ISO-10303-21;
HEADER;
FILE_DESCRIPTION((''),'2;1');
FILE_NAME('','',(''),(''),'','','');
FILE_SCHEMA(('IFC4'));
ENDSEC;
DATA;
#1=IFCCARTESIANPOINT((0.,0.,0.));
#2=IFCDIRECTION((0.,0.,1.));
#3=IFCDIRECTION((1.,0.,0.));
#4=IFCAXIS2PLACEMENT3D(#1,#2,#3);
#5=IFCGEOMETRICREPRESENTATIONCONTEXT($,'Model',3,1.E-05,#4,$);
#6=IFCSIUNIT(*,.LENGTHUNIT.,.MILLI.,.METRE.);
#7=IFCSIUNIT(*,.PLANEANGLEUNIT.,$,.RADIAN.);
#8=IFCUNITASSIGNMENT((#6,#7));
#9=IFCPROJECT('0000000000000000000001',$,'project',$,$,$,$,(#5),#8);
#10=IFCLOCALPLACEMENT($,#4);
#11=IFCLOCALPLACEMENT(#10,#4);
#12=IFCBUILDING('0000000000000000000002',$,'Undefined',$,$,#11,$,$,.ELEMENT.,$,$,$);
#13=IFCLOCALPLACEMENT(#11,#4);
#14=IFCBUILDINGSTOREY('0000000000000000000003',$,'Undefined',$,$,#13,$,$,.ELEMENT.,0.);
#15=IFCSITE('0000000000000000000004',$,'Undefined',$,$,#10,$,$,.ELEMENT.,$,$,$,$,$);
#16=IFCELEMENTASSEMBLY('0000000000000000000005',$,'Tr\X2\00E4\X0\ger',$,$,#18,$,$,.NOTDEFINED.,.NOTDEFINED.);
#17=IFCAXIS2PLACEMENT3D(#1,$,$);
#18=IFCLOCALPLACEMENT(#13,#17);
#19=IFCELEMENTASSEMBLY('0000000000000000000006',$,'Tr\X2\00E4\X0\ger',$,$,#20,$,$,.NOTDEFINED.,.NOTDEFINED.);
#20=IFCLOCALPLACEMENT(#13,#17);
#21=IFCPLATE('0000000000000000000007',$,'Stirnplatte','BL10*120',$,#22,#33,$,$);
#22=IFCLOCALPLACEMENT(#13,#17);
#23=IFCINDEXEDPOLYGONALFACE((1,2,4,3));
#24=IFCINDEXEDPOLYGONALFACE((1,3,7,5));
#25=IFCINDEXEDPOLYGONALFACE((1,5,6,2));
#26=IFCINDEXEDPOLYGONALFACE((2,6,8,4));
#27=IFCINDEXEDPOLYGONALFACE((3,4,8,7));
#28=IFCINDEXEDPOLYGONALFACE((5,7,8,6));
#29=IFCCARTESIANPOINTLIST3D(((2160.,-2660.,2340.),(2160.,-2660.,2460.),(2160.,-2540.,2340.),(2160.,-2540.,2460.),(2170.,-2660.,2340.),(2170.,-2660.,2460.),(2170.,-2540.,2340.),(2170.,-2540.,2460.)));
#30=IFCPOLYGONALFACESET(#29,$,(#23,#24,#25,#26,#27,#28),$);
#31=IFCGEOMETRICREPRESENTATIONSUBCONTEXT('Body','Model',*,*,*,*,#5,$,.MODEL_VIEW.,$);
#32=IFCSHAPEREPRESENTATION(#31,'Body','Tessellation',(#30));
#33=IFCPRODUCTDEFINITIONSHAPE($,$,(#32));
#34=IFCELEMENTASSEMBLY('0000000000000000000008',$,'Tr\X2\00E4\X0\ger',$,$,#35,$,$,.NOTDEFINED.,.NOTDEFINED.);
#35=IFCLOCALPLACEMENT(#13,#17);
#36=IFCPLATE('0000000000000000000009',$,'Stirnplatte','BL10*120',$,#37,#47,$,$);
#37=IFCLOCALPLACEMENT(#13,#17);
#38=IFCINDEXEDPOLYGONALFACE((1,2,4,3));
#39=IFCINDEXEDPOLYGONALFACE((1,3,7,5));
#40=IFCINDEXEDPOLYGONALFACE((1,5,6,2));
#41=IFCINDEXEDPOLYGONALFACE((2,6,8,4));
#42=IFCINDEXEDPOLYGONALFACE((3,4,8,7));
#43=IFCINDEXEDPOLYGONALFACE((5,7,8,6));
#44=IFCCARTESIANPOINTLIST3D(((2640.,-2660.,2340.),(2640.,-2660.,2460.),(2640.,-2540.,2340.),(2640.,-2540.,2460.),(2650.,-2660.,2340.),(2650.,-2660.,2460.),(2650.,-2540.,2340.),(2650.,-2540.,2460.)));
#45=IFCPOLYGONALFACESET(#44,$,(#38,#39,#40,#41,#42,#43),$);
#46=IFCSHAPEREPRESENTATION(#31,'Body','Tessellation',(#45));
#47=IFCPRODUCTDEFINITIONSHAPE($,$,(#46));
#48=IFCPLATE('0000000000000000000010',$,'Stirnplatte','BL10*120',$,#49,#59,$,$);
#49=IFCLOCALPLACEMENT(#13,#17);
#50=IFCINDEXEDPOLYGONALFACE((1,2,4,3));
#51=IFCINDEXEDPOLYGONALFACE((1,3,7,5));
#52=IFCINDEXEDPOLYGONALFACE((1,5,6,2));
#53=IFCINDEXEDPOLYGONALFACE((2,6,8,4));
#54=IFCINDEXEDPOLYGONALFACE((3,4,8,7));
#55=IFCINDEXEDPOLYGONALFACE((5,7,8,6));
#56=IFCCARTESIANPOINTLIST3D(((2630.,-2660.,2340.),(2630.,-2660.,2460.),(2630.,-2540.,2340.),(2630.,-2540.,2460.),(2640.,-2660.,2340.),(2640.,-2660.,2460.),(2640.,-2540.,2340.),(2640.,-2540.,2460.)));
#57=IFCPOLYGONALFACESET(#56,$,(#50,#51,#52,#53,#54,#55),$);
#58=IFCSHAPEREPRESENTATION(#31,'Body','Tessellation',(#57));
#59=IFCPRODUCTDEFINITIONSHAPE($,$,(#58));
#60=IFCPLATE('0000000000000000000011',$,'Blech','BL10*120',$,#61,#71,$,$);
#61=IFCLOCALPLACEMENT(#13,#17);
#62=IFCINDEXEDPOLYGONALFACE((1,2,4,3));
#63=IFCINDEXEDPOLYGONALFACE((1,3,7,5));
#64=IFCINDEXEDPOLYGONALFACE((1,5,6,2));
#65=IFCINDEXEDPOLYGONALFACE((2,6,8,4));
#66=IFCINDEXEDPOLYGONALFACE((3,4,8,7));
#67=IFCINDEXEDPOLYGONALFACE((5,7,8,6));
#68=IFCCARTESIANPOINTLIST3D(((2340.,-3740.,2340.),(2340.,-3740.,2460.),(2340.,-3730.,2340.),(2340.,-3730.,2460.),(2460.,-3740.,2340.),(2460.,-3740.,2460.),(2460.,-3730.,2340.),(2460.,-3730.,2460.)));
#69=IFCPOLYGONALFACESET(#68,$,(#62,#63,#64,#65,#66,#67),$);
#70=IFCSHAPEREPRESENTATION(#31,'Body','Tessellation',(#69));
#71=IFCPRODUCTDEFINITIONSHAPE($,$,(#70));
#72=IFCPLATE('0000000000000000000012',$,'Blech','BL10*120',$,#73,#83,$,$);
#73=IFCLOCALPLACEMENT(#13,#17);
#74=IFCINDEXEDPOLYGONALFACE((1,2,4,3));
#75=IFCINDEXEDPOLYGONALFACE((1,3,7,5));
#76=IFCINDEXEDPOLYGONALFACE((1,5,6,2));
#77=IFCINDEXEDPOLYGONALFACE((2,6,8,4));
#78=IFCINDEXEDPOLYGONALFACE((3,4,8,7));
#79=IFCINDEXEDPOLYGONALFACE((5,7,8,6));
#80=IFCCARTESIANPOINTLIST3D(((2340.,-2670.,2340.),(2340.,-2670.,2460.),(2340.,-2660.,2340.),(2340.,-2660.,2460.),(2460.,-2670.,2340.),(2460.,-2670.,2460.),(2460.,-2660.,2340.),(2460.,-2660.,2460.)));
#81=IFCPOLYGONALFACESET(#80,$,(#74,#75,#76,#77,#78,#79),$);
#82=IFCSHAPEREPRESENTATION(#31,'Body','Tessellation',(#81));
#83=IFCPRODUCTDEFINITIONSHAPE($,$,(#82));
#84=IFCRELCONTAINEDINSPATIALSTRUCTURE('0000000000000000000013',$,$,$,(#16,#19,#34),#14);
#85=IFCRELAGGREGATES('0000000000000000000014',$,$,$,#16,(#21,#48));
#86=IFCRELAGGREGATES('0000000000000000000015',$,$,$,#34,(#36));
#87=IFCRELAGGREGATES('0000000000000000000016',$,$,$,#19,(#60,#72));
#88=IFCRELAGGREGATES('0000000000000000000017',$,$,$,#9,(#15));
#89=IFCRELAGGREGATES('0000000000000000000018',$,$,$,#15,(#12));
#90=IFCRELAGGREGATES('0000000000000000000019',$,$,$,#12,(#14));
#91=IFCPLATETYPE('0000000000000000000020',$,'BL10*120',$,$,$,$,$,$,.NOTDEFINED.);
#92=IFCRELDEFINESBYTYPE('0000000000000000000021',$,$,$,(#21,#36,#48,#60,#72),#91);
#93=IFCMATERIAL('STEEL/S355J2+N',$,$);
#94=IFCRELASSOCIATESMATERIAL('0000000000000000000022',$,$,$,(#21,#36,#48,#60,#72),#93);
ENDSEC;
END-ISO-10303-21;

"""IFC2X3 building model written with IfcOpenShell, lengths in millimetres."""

from ifc_helpers import new_model, si_unit, frame, origin_with_axes, place, context, subcontext, project, spatial, polyline, outline, extrude, material, type_object, element, aggregate, save


model = new_model("IFC2X3")

# Units and contexts
model_context = context("Model", 3, precision=1e-05, world=origin_with_axes())
body_context = subcontext(model_context, "Body", "Model", "MODEL_VIEW")
ifc_project = project(units=[si_unit("LENGTHUNIT", "METRE", prefix="MILLI"), si_unit("PLANEANGLEUNIT", "RADIAN")], contexts=[model_context])

# Site, building, storey
site_placement = place(None, origin_with_axes())
site = spatial("IfcSite", under=ifc_project, at=site_placement, Name="Undefined", CompositionType="ELEMENT")
building_placement = place(site_placement, origin_with_axes())
building = spatial("IfcBuilding", under=site, at=building_placement, Name="Undefined", CompositionType="ELEMENT")
storey_placement = place(building_placement, origin_with_axes())
storey = spatial("IfcBuildingStorey", under=building, at=storey_placement, Name="Undefined", CompositionType="ELEMENT", Elevation=0.0)

# Element assemblies
assembly_1_placement = place(storey_placement, origin_with_axes())
assembly_1 = element("IfcElementAssembly", 1, at=assembly_1_placement, inside=storey, Name="Träger", AssemblyPlace="NOTDEFINED", PredefinedType="NOTDEFINED")
assembly_2_placement = place(storey_placement, origin_with_axes())
assembly_2 = element("IfcElementAssembly", 2, at=assembly_2_placement, inside=storey, Name="Träger", AssemblyPlace="NOTDEFINED", PredefinedType="NOTDEFINED")

# Shared definitions
ifc_material_1 = material(Name="STEEL/S355J2+N")
plate_type = type_object("IfcPlateType", Name="BL10*120", PredefinedType="NOTDEFINED")

# Plate
plate_1_placement = place(assembly_1_placement, frame((2165.0, -2600.0, 2340.0), z_axis=(-1.0, 0.0, 0.0), x_axis=(0.0, 0.0, 1.0)))
plate_1 = element("IfcPlate", 3, at=plate_1_placement, type_object=plate_type, material=ifc_material_1, Name="Stirnplatte", Description="BL10*120", context=body_context, shape_type="SweptSolid", body=[
    extrude(outline(polyline([(0.0, -60.0), (0.0, 60.0), (120.0, 60.0), (120.0, -60.0), (0.0, -60.0)])), frame((0.0, 0.0, -5.0), z_axis=(0.0, 0.0, 1.0), x_axis=(1.0, 0.0, 0.0)), (0.0, 0.0, 1.0), 10.0),
])

# Element assembly, plate
assembly_3_placement = place(storey_placement, origin_with_axes())
assembly_3 = element("IfcElementAssembly", 4, at=assembly_3_placement, inside=storey, Name="Träger", AssemblyPlace="NOTDEFINED", PredefinedType="NOTDEFINED")
plate_2_placement = place(assembly_3_placement, frame((2645.0, -2600.0, 2340.0), z_axis=(1.0, 0.0, 0.0), x_axis=(0.0, 0.0, 1.0)))
plate_2 = element("IfcPlate", 5, at=plate_2_placement, type_object=plate_type, material=ifc_material_1, Name="Stirnplatte", Description="BL10*120", context=body_context, shape_type="SweptSolid", body=[
    extrude(outline(polyline([(0.0, -60.0), (0.0, 60.0), (120.0, 60.0), (120.0, -60.0), (0.0, -60.0)])), frame((0.0, 0.0, -5.0), z_axis=(0.0, 0.0, 1.0), x_axis=(1.0, 0.0, 0.0)), (0.0, 0.0, 1.0), 10.0),
])

# Plates
plate_3_placement = place(assembly_1_placement, frame((2635.0, -2600.0, 2340.0), z_axis=(1.0, 0.0, 0.0), x_axis=(0.0, 0.0, 1.0)))
plate_3 = element("IfcPlate", 6, at=plate_3_placement, type_object=plate_type, material=ifc_material_1, Name="Stirnplatte", Description="BL10*120", context=body_context, shape_type="SweptSolid", body=[
    extrude(outline(polyline([(0.0, -60.0), (0.0, 60.0), (120.0, 60.0), (120.0, -60.0), (0.0, -60.0)])), frame((0.0, 0.0, -5.0), z_axis=(0.0, 0.0, 1.0), x_axis=(1.0, 0.0, 0.0)), (0.0, 0.0, 1.0), 10.0),
])
aggregate(assembly_1, [plate_1, plate_3])
plate_4_placement = place(assembly_2_placement, frame((2400.0, -3735.0, 2340.0), z_axis=(0.0, 1.0, 0.0), x_axis=(0.0, 0.0, 1.0)))
plate_4 = element("IfcPlate", 7, at=plate_4_placement, type_object=plate_type, material=ifc_material_1, Name="Blech", Description="BL10*120", context=body_context, shape_type="SweptSolid", body=[
    extrude(outline(polyline([(0.0, -60.0), (0.0, 60.0), (120.0, 60.0), (120.0, -60.0), (0.0, -60.0)])), frame((0.0, 0.0, -5.0), z_axis=(0.0, 0.0, 1.0), x_axis=(1.0, 0.0, 0.0)), (0.0, 0.0, 1.0), 10.0),
])
plate_5_placement = place(assembly_2_placement, frame((2400.0, -2665.0, 2340.0), z_axis=(0.0, -1.0, 0.0), x_axis=(0.0, 0.0, 1.0)))
plate_5 = element("IfcPlate", 8, at=plate_5_placement, type_object=plate_type, material=ifc_material_1, Name="Blech", Description="BL10*120", context=body_context, shape_type="SweptSolid", body=[
    extrude(outline(polyline([(0.0, -60.0), (0.0, 60.0), (120.0, 60.0), (120.0, -60.0), (0.0, -60.0)])), frame((0.0, 0.0, -5.0), z_axis=(0.0, 0.0, 1.0), x_axis=(1.0, 0.0, 0.0)), (0.0, 0.0, 1.0), 10.0),
])

aggregate(assembly_3, [plate_2])
aggregate(assembly_2, [plate_4, plate_5])

save(model, "model.ifc")
